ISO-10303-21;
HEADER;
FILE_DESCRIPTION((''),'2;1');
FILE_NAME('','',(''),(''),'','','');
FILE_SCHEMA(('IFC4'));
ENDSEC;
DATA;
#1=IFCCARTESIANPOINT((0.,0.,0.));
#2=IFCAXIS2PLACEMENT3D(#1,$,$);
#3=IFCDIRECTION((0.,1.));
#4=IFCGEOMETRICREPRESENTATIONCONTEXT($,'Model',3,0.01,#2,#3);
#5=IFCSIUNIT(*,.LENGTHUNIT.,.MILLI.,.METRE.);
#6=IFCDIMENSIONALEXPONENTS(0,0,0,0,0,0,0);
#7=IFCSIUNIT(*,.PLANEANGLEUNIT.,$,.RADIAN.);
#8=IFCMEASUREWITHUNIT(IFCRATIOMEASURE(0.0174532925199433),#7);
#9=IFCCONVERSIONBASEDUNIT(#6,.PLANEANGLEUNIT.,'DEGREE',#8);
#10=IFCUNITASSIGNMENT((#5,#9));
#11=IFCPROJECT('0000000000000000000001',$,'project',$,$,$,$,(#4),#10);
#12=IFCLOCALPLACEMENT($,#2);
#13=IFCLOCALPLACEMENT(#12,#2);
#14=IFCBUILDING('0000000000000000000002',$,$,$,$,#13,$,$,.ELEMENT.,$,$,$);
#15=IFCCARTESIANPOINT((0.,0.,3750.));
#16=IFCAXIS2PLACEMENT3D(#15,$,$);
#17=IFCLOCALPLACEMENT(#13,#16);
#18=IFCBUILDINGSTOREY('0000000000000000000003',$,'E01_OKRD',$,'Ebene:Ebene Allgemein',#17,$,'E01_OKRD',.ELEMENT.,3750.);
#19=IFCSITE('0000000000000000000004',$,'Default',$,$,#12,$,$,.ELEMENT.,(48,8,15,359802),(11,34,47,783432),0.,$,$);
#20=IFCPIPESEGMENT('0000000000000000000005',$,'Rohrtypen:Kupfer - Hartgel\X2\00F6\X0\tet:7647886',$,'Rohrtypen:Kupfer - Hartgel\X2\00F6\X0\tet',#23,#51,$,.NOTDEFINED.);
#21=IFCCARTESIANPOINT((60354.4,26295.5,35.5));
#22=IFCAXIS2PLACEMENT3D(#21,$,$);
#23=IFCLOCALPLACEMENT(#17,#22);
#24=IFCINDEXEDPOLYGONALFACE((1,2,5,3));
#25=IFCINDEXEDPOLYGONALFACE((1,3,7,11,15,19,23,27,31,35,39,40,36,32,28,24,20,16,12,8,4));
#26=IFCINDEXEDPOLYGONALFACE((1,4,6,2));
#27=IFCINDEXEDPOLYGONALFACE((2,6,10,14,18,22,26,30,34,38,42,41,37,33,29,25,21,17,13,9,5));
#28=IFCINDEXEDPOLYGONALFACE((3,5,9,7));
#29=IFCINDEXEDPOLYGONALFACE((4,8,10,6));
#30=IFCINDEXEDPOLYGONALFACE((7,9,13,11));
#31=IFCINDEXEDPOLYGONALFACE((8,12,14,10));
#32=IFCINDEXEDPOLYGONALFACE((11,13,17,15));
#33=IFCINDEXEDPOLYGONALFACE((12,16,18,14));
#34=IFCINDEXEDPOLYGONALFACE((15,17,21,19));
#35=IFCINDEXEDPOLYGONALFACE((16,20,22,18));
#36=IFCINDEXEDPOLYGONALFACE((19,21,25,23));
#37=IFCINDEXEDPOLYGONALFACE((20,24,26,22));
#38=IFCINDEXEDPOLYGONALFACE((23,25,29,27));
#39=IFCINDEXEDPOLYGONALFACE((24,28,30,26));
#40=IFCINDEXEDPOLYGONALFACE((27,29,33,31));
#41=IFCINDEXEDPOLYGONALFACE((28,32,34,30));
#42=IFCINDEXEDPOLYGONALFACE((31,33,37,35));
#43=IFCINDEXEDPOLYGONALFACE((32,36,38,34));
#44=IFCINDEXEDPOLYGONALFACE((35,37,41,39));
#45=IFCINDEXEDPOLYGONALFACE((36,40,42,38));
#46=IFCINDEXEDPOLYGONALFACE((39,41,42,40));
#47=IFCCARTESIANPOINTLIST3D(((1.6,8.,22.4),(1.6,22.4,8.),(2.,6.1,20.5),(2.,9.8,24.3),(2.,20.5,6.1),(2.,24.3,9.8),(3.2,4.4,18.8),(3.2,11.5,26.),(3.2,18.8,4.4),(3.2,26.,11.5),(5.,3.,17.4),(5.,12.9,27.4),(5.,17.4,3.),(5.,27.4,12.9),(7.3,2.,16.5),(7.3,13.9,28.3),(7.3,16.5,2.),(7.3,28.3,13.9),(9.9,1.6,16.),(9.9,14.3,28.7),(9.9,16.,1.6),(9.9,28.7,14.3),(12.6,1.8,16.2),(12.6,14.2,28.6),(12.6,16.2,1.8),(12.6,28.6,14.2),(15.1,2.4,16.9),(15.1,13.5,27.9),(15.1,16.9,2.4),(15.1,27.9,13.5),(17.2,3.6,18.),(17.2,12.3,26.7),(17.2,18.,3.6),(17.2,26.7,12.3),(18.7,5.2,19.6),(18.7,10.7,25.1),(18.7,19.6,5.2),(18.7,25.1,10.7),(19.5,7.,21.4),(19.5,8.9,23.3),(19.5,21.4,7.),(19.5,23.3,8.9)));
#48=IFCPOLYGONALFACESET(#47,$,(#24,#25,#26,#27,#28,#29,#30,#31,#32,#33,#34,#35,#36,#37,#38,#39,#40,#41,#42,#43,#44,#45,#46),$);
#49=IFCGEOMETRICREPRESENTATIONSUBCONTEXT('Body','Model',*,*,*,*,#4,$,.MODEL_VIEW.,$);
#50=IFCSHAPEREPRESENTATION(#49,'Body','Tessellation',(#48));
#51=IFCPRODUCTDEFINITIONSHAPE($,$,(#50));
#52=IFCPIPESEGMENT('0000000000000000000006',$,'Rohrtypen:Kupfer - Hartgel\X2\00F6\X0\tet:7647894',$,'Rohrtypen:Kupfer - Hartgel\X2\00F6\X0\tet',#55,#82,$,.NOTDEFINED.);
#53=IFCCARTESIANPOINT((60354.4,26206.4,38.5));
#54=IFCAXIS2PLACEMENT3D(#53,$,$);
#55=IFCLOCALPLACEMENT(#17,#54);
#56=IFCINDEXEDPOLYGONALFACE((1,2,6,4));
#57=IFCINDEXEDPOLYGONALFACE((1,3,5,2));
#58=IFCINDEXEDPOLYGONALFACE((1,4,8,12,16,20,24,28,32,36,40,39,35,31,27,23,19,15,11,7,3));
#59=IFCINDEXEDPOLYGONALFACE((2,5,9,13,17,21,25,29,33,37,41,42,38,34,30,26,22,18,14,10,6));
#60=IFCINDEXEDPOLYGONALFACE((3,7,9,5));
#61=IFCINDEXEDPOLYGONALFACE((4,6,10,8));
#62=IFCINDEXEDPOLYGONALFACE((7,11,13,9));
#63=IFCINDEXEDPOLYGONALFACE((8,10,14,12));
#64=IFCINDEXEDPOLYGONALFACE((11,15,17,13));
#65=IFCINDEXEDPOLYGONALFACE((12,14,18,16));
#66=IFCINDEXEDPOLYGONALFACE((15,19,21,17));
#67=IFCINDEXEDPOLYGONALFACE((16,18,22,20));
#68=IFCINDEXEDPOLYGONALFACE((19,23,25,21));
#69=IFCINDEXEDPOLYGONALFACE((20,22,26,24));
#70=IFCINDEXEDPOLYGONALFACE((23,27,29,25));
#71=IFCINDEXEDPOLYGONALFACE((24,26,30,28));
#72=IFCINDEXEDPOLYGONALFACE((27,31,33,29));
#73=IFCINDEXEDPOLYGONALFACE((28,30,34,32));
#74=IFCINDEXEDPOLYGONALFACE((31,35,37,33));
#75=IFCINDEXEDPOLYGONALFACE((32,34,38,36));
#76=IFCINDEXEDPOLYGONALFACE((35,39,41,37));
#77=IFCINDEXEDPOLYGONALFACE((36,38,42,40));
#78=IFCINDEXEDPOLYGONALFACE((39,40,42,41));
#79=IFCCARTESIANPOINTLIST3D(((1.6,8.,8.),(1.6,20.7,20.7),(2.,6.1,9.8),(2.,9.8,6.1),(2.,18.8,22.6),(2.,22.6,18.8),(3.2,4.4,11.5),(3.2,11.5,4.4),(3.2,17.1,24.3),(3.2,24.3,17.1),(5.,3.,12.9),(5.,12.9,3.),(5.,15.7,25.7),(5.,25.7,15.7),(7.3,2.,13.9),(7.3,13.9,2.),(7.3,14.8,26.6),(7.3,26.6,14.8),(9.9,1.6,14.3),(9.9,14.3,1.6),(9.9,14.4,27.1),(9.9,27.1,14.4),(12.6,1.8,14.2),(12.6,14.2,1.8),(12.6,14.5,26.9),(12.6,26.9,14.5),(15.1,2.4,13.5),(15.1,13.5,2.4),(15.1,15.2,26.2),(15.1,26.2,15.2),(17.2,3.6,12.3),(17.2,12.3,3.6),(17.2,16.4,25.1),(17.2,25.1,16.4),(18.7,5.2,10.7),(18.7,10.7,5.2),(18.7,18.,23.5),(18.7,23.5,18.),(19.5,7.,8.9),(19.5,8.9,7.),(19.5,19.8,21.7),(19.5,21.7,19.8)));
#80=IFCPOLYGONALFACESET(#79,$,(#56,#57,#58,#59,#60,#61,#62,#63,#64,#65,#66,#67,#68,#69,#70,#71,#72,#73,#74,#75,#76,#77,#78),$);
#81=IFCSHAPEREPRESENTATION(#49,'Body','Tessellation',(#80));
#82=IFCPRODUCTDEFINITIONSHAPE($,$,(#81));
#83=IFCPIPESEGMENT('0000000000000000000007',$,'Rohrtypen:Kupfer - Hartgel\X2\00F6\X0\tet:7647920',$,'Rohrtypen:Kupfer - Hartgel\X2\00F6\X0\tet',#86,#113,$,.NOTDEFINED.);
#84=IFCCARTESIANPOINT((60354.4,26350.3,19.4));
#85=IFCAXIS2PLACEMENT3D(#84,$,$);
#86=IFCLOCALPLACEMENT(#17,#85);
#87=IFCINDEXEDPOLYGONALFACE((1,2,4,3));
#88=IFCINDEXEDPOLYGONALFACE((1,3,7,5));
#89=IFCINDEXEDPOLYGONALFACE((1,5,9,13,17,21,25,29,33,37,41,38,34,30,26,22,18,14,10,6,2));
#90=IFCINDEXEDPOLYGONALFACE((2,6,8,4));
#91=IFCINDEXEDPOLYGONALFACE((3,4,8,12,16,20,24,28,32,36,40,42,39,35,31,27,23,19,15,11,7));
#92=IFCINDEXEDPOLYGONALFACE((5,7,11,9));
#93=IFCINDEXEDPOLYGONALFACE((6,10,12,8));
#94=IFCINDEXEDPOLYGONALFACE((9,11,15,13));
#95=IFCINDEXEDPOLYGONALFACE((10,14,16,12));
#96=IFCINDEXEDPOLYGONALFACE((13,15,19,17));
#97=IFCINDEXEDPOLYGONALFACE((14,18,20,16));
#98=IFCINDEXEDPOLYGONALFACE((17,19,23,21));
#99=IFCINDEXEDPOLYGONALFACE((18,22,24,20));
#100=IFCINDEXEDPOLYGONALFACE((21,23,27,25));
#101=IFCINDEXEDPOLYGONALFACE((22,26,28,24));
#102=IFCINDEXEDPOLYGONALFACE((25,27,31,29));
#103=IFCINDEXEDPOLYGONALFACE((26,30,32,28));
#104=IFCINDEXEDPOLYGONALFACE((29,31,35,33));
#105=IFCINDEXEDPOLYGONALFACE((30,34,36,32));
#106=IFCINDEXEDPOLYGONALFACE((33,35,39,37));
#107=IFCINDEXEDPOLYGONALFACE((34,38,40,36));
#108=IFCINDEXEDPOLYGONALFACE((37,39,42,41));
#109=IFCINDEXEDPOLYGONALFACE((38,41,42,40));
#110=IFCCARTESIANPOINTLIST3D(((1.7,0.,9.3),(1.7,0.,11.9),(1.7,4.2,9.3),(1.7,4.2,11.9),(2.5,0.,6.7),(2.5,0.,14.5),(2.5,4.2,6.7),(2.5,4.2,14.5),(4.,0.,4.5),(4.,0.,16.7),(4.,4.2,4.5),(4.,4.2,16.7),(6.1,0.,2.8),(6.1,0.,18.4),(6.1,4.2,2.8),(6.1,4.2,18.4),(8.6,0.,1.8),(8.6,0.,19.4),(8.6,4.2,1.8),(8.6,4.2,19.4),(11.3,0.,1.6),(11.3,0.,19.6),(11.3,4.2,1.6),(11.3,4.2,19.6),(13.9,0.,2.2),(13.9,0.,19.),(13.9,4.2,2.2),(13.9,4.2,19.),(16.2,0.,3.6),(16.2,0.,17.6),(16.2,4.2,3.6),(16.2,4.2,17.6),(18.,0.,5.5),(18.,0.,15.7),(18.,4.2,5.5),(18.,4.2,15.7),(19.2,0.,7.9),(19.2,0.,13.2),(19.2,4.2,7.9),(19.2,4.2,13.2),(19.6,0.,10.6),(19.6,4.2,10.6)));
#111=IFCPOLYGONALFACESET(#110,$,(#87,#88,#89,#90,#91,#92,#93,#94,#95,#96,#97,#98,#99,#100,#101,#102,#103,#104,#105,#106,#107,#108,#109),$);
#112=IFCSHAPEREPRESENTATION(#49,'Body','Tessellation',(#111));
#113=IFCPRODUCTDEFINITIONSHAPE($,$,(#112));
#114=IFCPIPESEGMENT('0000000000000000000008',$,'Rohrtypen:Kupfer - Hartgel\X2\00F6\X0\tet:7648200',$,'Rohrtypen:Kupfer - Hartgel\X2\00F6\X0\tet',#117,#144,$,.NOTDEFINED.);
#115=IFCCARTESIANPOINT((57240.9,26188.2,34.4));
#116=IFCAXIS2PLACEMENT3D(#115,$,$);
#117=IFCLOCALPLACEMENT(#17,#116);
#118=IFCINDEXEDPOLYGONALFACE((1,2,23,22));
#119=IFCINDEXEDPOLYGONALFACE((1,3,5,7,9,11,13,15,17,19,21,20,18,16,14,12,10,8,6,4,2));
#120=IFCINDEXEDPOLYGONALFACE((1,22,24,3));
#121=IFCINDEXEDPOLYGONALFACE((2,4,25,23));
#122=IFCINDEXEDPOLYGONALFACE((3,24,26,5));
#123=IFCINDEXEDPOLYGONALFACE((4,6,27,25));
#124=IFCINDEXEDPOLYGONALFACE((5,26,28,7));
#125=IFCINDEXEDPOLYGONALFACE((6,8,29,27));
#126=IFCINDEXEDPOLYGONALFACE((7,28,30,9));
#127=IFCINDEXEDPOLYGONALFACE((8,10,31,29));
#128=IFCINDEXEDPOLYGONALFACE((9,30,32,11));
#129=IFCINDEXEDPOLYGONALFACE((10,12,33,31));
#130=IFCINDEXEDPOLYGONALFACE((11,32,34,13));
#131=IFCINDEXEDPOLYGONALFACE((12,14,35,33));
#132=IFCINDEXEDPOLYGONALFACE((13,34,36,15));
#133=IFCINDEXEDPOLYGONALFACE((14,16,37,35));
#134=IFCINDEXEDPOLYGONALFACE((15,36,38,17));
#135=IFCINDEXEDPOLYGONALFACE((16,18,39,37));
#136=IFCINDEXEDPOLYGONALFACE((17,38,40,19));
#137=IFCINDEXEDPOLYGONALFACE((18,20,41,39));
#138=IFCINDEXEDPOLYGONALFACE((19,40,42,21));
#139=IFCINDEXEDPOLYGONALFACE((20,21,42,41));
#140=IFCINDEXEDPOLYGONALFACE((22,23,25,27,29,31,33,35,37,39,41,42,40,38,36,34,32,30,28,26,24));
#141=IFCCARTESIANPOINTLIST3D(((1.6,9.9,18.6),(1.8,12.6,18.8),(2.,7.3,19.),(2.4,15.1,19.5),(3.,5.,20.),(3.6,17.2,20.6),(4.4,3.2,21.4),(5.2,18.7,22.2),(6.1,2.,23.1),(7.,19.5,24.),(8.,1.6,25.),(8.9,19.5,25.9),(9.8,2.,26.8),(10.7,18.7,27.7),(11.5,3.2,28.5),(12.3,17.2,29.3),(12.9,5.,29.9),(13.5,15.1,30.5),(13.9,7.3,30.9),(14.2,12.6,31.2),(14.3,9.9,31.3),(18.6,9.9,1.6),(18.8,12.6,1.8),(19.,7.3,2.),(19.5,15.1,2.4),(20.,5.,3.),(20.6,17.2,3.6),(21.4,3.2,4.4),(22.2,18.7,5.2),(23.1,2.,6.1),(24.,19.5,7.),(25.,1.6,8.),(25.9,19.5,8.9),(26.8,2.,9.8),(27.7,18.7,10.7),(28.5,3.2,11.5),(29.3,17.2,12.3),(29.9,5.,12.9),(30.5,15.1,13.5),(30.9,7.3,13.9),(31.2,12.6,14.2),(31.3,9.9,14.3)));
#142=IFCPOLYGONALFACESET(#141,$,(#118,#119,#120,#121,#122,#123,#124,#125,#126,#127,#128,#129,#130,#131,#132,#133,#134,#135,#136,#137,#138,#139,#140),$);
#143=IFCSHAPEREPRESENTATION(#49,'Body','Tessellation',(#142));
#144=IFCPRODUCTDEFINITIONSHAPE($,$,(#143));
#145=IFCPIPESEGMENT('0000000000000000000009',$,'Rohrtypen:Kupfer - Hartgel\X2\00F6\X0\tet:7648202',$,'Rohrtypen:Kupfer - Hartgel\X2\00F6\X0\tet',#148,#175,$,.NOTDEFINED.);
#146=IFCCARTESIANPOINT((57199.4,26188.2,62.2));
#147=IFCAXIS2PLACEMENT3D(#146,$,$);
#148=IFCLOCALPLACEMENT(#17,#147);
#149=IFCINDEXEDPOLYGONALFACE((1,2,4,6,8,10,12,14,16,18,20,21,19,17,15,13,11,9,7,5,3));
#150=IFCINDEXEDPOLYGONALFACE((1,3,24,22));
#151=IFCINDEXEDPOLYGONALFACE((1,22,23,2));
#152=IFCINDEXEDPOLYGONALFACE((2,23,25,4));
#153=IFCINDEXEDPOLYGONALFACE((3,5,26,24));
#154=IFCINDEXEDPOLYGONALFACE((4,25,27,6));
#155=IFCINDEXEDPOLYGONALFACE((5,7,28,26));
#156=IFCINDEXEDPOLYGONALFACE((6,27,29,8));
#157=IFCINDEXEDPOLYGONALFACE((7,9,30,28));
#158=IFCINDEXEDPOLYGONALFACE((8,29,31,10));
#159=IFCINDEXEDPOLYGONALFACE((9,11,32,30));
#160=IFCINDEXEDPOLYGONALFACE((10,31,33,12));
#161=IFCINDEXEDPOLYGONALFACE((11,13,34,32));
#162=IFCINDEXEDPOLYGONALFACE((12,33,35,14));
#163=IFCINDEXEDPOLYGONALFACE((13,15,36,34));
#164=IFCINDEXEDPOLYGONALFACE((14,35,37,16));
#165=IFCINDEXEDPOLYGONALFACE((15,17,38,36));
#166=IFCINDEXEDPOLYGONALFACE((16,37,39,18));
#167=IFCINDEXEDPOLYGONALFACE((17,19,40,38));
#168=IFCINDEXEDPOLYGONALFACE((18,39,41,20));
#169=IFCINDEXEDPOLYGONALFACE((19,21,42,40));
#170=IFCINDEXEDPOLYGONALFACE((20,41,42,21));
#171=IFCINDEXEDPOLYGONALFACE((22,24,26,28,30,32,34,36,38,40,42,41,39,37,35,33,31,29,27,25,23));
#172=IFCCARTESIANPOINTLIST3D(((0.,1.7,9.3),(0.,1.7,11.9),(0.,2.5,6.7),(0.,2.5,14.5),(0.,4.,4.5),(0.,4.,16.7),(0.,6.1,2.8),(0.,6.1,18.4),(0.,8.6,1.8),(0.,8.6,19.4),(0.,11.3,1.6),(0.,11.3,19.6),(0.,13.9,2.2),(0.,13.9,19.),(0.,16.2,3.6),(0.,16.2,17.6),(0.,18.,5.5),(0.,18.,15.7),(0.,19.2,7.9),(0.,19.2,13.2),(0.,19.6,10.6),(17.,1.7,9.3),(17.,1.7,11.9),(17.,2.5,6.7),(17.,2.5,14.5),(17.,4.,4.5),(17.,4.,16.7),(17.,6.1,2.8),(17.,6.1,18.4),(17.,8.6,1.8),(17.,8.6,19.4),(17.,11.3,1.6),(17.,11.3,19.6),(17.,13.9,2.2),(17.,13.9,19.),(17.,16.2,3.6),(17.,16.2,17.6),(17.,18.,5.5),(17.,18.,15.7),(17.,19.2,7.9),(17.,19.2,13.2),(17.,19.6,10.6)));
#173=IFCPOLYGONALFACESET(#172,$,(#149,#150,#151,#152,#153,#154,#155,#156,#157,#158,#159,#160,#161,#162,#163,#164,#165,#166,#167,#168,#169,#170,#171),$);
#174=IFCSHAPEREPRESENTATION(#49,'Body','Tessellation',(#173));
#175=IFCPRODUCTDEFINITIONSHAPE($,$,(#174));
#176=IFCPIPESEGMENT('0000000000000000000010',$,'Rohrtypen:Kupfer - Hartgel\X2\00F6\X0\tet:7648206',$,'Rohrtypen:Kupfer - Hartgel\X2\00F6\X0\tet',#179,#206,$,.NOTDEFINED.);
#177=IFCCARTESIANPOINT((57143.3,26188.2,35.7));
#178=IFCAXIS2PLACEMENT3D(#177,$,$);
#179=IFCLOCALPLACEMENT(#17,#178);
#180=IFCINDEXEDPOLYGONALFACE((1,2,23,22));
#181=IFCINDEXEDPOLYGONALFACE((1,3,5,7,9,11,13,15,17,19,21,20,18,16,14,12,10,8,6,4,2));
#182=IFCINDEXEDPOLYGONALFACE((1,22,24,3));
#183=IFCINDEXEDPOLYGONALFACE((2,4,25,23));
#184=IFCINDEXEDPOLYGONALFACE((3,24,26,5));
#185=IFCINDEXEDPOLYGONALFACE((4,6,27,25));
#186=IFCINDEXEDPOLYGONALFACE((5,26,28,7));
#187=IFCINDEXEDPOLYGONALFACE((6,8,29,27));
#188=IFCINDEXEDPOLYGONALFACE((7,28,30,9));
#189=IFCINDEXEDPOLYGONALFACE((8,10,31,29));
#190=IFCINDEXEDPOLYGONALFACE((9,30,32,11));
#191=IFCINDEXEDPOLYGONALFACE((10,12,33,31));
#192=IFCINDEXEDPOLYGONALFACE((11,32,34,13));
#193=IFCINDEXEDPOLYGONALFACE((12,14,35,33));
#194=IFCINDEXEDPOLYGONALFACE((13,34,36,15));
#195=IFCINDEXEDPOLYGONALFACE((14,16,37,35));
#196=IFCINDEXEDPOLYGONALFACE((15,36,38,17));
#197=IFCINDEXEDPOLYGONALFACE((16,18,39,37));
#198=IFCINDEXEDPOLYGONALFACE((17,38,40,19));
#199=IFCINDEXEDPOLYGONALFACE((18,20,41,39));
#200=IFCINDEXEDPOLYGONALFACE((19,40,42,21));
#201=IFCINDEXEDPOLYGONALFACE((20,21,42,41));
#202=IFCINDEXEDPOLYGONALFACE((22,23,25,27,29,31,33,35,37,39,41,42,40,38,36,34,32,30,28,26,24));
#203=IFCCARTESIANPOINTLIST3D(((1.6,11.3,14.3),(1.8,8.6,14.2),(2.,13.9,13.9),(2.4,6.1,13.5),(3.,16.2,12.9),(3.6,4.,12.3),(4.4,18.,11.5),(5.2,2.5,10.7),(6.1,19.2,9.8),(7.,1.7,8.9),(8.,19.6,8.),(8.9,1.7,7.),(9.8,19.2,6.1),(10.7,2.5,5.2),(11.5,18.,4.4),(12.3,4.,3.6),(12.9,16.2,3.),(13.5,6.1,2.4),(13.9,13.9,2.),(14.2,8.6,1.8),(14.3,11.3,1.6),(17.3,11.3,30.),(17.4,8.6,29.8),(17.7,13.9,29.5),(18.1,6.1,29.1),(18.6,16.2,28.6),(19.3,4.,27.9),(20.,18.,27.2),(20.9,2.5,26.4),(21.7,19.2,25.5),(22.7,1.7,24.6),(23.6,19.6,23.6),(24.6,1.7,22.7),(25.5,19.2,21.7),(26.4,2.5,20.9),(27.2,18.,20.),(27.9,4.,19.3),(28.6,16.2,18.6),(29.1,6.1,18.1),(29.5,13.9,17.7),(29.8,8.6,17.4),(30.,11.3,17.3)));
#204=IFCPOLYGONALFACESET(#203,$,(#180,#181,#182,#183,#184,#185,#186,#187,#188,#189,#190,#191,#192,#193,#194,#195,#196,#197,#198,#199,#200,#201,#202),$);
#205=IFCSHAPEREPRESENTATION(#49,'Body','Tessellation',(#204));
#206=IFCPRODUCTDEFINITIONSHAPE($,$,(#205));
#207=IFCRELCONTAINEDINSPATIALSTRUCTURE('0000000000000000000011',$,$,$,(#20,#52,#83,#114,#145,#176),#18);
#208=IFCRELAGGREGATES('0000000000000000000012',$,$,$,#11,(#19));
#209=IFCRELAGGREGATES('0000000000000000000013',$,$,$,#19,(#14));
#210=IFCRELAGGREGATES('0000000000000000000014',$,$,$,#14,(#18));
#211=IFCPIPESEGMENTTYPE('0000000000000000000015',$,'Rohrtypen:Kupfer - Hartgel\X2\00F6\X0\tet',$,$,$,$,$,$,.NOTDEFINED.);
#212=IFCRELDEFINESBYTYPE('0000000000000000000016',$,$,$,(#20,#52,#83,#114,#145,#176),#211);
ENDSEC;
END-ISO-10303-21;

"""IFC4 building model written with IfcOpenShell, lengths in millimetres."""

from ifc_helpers import new_model, entity, si_unit, converted_unit, direction, frame, frame_2d, origin, origin_2d_with_axis, place, context, subcontext, project, spatial, circle, extrude, type_object, element, save


model = new_model("IFC4")

# Units and contexts
model_context = context("Model", 3, precision=0.01, world=origin(), true_north=direction((0.0, 1.0)))
body_context = subcontext(model_context, "Body", "Model", "MODEL_VIEW")
ifc_project = project(units=[si_unit("LENGTHUNIT", "METRE", prefix="MILLI"), converted_unit("PLANEANGLEUNIT", "DEGREE", entity("IfcRatioMeasure", 0.0174532925199433), si_unit("PLANEANGLEUNIT", "RADIAN"), dimensions=[0, 0, 0, 0, 0, 0, 0])], contexts=[model_context])

# Site, building, storey
site_placement = place(None, origin())
site = spatial("IfcSite", under=ifc_project, at=site_placement, Name="Default", CompositionType="ELEMENT", RefLatitude=(48, 8, 15, 359802), RefLongitude=(11, 34, 47, 783432), RefElevation=0.0)
building_placement = place(site_placement, origin())
building = spatial("IfcBuilding", under=site, at=building_placement, CompositionType="ELEMENT")
storey_placement = place(building_placement, frame((0.0, 0.0, 3750.0)))
storey = spatial("IfcBuildingStorey", under=building, at=storey_placement, Name="E01_OKRD", ObjectType="Ebene:Ebene Allgemein", LongName="E01_OKRD", CompositionType="ELEMENT", Elevation=3750.0)

# Pipe segments
pipe_segment_type = type_object("IfcPipeSegmentType", Name="Rohrtypen:Kupfer - Hartgelötet", PredefinedType="NOTDEFINED")
pipe_segment_1_placement = place(storey_placement, frame((60354.4, 26295.5, 35.5)))
element("IfcPipeSegment", 1, at=pipe_segment_1_placement, inside=storey, type_object=pipe_segment_type, Name="Rohrtypen:Kupfer - Hartgelötet:7647886", ObjectType="Rohrtypen:Kupfer - Hartgelötet", PredefinedType="NOTDEFINED", context=body_context, shape_type="SweptSolid", body=[
    extrude(circle(Radius=9.0, at=origin_2d_with_axis()), frame((10.6, 22.4, 8.0), z_axis=(0.0, -0.707107, 0.707107), x_axis=(-1.0, 0.0, 0.0)), (0.0, 0.0, 1.0), 20.4),
])
pipe_segment_2_placement = place(storey_placement, frame((60354.4, 26206.4, 38.5)))
element("IfcPipeSegment", 2, at=pipe_segment_2_placement, inside=storey, type_object=pipe_segment_type, Name="Rohrtypen:Kupfer - Hartgelötet:7647894", ObjectType="Rohrtypen:Kupfer - Hartgelötet", PredefinedType="NOTDEFINED", context=body_context, shape_type="SweptSolid", body=[
    extrude(circle(Radius=9.0, at=frame_2d((0.0, 0.0), x_axis=(1.0, 0.0))), frame((10.6, 8.0, 8.0), z_axis=(0.0, 0.707107, 0.707107), x_axis=(-1.0, 0.0, 0.0)), (0.0, 0.0, 1.0), 18.1),
])
pipe_segment_3_placement = place(storey_placement, frame((60354.4, 26350.3, 19.4)))
element("IfcPipeSegment", 3, at=pipe_segment_3_placement, inside=storey, type_object=pipe_segment_type, Name="Rohrtypen:Kupfer - Hartgelötet:7647920", ObjectType="Rohrtypen:Kupfer - Hartgelötet", PredefinedType="NOTDEFINED", context=body_context, shape_type="SweptSolid", body=[
    extrude(circle(Radius=9.0, at=origin_2d_with_axis()), frame((10.6, 0.0, 10.6), z_axis=(0.0, 1.0, 0.0), x_axis=(1.0, 0.0, 0.0)), (0.0, 0.0, 1.0), 4.2),
])
pipe_segment_4_placement = place(storey_placement, frame((57240.9, 26188.2, 34.4)))
element("IfcPipeSegment", 4, at=pipe_segment_4_placement, inside=storey, type_object=pipe_segment_type, Name="Rohrtypen:Kupfer - Hartgelötet:7648200", ObjectType="Rohrtypen:Kupfer - Hartgelötet", PredefinedType="NOTDEFINED", context=body_context, shape_type="SweptSolid", body=[
    extrude(circle(Radius=9.0, at=origin_2d_with_axis()), frame((25.0, 10.6, 8.0), z_axis=(-0.707107, 0.0, 0.707107), x_axis=(0.0, -1.0, 0.0)), (0.0, 0.0, 1.0), 24.0),
])
pipe_segment_5_placement = place(storey_placement, frame((57199.4, 26188.2, 62.2)))
element("IfcPipeSegment", 5, at=pipe_segment_5_placement, inside=storey, type_object=pipe_segment_type, Name="Rohrtypen:Kupfer - Hartgelötet:7648202", ObjectType="Rohrtypen:Kupfer - Hartgelötet", PredefinedType="NOTDEFINED", context=body_context, shape_type="SweptSolid", body=[
    extrude(circle(Radius=9.0, at=origin_2d_with_axis()), frame((0.0, 10.6, 10.6), z_axis=(1.0, 0.0, 0.0), x_axis=(0.0, 1.0, 0.0)), (0.0, 0.0, 1.0), 17.0),
])
pipe_segment_6_placement = place(storey_placement, frame((57143.3, 26188.2, 35.7)))
element("IfcPipeSegment", 6, at=pipe_segment_6_placement, inside=storey, type_object=pipe_segment_type, Name="Rohrtypen:Kupfer - Hartgelötet:7648206", ObjectType="Rohrtypen:Kupfer - Hartgelötet", PredefinedType="NOTDEFINED", context=body_context, shape_type="SweptSolid", body=[
    extrude(circle(Radius=9.0, at=origin_2d_with_axis()), frame((8.0, 10.6, 8.0), z_axis=(0.707107, 0.0, 0.707107), x_axis=(0.0, 1.0, 0.0)), (0.0, 0.0, 1.0), 22.1),
])

save(model, "model.ifc")
